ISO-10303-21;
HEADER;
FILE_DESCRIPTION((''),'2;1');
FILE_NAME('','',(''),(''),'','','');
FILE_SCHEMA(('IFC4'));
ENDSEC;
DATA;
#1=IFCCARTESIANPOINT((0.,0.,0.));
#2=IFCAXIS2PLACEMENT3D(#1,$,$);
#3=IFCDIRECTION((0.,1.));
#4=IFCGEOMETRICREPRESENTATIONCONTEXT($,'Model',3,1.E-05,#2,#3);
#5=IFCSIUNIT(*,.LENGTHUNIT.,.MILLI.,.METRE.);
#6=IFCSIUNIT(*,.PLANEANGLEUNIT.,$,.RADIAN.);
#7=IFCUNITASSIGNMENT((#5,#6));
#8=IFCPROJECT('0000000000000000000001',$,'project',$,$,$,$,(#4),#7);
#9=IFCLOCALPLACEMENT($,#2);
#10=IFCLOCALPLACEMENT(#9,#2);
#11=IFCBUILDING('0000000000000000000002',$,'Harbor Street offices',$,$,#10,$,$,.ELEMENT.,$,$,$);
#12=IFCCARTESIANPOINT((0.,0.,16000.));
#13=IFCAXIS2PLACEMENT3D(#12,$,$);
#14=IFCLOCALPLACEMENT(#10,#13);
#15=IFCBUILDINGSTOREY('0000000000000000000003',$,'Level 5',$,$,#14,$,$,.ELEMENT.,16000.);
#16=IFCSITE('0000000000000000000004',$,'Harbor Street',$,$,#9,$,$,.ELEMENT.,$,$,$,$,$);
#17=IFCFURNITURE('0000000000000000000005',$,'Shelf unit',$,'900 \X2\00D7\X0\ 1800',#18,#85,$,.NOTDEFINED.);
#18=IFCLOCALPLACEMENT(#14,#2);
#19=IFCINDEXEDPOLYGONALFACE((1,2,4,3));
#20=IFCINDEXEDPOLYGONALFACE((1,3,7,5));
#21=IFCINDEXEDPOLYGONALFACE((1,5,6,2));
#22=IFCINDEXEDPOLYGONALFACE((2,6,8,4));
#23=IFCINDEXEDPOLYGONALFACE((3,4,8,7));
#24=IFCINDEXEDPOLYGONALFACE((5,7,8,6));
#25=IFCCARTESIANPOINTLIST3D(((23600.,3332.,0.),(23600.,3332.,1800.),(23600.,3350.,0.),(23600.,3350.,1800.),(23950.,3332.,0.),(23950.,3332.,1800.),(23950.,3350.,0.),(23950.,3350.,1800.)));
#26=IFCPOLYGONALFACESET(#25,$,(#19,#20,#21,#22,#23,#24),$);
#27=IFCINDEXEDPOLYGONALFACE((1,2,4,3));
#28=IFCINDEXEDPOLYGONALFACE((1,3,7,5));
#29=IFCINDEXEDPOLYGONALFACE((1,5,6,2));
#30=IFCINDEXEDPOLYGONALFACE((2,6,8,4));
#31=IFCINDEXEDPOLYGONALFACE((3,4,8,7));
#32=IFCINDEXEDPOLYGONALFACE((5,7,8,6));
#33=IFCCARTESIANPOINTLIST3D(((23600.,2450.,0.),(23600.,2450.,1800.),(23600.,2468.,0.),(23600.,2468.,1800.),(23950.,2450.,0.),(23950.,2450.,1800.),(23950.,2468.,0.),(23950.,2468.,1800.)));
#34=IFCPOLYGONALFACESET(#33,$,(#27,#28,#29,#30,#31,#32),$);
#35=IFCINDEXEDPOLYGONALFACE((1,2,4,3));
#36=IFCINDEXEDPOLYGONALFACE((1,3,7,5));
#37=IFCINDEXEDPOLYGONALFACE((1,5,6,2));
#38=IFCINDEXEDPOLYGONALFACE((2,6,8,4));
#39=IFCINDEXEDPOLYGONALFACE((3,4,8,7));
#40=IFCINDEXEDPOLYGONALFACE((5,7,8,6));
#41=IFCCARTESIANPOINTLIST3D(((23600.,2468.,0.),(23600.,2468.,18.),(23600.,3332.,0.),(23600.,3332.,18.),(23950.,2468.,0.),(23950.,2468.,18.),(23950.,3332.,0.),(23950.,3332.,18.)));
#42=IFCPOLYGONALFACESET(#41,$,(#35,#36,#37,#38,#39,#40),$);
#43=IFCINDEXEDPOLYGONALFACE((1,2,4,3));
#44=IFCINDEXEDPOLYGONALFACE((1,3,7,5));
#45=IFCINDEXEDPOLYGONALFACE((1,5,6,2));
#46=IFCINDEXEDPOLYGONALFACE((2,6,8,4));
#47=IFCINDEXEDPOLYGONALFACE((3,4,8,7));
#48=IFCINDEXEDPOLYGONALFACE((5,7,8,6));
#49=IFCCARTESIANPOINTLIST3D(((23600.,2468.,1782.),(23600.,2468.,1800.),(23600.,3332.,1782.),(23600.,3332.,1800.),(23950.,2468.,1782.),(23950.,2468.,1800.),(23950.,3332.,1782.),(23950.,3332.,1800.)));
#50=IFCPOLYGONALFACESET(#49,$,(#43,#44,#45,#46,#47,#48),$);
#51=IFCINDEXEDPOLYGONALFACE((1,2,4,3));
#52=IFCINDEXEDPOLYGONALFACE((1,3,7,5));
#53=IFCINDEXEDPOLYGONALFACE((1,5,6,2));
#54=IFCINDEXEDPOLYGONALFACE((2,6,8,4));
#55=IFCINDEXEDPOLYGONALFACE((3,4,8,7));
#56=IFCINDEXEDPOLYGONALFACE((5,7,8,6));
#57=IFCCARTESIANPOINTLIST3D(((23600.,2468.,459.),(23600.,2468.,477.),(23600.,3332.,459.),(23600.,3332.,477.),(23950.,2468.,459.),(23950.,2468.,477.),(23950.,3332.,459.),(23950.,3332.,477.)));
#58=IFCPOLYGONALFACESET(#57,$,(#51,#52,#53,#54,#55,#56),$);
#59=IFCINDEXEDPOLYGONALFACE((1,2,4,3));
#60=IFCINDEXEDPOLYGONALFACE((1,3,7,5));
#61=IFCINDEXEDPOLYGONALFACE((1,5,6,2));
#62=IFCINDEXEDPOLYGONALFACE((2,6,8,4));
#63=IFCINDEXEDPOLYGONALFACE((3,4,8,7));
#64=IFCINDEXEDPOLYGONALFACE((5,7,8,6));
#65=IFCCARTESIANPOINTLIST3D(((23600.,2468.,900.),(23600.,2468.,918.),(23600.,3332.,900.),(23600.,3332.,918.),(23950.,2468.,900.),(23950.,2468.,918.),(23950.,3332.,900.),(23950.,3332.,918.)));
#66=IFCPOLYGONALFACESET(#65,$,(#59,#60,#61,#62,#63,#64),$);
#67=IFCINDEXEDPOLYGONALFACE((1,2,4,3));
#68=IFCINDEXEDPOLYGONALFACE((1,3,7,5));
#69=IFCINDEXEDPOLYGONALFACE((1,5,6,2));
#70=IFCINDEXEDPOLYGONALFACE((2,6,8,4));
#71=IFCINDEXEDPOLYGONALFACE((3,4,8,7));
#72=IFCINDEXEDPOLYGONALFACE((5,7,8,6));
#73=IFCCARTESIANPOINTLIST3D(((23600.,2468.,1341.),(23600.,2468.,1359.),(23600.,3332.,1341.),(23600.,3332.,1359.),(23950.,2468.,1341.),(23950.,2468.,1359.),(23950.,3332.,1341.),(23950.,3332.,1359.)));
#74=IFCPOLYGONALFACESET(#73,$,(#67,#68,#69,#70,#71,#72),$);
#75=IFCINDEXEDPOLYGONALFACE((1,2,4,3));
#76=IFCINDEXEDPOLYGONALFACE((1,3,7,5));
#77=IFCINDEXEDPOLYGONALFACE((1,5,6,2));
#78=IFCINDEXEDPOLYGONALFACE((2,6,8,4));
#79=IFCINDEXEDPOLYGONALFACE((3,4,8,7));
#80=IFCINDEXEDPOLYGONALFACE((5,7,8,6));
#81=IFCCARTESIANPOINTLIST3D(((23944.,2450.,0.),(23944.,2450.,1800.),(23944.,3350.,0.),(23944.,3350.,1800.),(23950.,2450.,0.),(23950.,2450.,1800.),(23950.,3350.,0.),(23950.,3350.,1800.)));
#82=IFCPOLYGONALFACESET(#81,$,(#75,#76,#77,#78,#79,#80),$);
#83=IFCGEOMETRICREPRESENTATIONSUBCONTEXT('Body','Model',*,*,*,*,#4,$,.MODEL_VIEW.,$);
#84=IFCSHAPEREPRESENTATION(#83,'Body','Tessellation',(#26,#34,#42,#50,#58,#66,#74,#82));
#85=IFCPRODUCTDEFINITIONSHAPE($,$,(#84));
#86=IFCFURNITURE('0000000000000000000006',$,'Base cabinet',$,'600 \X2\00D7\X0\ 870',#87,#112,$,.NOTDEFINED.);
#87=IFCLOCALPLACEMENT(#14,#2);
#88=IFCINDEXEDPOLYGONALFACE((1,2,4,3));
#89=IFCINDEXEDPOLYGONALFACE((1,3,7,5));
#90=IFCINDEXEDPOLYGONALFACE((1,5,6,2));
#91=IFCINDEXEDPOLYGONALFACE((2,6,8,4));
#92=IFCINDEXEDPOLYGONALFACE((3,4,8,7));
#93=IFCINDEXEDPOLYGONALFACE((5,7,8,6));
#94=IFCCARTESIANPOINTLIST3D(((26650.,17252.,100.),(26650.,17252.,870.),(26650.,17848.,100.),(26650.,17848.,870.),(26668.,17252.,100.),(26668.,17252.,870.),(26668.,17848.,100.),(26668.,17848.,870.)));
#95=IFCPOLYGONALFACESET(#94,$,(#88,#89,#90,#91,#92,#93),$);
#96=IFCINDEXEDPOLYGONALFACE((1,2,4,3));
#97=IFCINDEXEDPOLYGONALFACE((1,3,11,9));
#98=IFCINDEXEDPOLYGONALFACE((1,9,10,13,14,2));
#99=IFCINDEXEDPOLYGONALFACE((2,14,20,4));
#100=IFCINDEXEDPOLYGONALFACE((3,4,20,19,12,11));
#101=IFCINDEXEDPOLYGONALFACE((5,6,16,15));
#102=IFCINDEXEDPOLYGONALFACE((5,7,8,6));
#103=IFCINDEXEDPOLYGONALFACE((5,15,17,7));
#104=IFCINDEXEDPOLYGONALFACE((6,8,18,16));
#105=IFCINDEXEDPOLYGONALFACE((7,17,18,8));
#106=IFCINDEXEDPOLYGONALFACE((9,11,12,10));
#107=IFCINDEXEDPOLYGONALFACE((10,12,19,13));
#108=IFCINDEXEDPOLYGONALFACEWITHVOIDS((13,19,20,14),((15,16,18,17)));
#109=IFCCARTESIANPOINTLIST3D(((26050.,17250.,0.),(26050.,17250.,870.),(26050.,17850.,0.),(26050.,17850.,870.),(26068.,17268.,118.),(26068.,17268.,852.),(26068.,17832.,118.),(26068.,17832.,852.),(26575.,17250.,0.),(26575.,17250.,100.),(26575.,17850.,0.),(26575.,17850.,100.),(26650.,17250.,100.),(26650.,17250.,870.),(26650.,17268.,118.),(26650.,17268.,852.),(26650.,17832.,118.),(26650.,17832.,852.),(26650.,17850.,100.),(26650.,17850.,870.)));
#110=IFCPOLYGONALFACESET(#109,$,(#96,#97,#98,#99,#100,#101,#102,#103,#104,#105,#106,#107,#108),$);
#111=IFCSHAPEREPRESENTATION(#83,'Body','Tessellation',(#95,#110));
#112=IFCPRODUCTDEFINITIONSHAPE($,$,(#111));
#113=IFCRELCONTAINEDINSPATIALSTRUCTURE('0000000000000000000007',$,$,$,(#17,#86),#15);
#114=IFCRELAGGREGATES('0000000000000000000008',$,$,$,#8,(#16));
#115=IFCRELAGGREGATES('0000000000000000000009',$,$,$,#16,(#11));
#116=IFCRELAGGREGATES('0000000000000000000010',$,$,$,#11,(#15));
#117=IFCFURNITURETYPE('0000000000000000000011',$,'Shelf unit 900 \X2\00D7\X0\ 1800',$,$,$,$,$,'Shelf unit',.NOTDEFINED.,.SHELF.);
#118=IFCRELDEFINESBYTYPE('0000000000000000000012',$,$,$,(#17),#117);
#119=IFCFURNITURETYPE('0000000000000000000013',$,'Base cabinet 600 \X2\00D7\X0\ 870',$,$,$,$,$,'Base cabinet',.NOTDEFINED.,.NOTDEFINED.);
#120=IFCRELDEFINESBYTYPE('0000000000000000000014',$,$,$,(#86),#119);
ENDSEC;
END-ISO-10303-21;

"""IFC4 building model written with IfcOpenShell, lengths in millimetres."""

from ifc_helpers import new_model, entity, si_unit, direction, frame, origin, place, context, subcontext, project, spatial, polyline, outline, extrude, source, transform, mapped, type_object, type_shapes, element, save


model = new_model("IFC4")

# Units and contexts
model_context = context("Model", 3, precision=1e-05, world=origin(), true_north=direction((0.0, 1.0)))
body_context = subcontext(model_context, "Body", "Model", "MODEL_VIEW")
ifc_project = project(units=[si_unit("LENGTHUNIT", "METRE", prefix="MILLI"), si_unit("PLANEANGLEUNIT", "RADIAN")], contexts=[model_context])

# Site, building, storey
site_placement = place(None, origin())
site = spatial("IfcSite", under=ifc_project, at=site_placement, Name="Harbor Street", CompositionType="ELEMENT")
building_placement = place(site_placement, origin())
building = spatial("IfcBuilding", under=site, at=building_placement, Name="Harbor Street offices", CompositionType="ELEMENT")
storey_placement = place(building_placement, frame((0.0, 0.0, 16000.0)))
storey = spatial("IfcBuildingStorey", under=building, at=storey_placement, Name="Level 5", CompositionType="ELEMENT", Elevation=16000.0)

# Furniture
furniture_type_1 = type_object("IfcFurnitureType", Name="Shelf unit 900 × 1800", ElementType="Shelf unit", AssemblyPlace="NOTDEFINED", PredefinedType="SHELF")
shared_shape_1 = source(origin(), body_context, "Body", "SweptSolid", [
    extrude(outline(polyline([(-450.0, 0.0), (-432.0, 0.0), (-432.0, 350.0), (-450.0, 350.0), (-450.0, 0.0)])), origin(), (0.0, 0.0, 1.0), 1800.0),
    extrude(outline(polyline([(432.0, 0.0), (450.0, 0.0), (450.0, 350.0), (432.0, 350.0), (432.0, 0.0)])), origin(), (0.0, 0.0, 1.0), 1800.0),
    extrude(outline(polyline([(-432.0, 0.0), (432.0, 0.0), (432.0, 350.0), (-432.0, 350.0), (-432.0, 0.0)])), origin(), (0.0, 0.0, 1.0), 18.0),
    extrude(outline(polyline([(-432.0, 0.0), (432.0, 0.0), (432.0, 350.0), (-432.0, 350.0), (-432.0, 0.0)])), frame((0.0, 0.0, 1782.0)), (0.0, 0.0, 1.0), 18.0),
    extrude(outline(polyline([(-432.0, 0.0), (432.0, 0.0), (432.0, 350.0), (-432.0, 350.0), (-432.0, 0.0)])), frame((0.0, 0.0, 459.0)), (0.0, 0.0, 1.0), 18.0),
    extrude(outline(polyline([(-432.0, 0.0), (432.0, 0.0), (432.0, 350.0), (-432.0, 350.0), (-432.0, 0.0)])), frame((0.0, 0.0, 900.0)), (0.0, 0.0, 1.0), 18.0),
    extrude(outline(polyline([(-432.0, 0.0), (432.0, 0.0), (432.0, 350.0), (-432.0, 350.0), (-432.0, 0.0)])), frame((0.0, 0.0, 1341.0)), (0.0, 0.0, 1.0), 18.0),
    extrude(outline(polyline([(-450.0, 344.0), (450.0, 344.0), (450.0, 350.0), (-450.0, 350.0), (-450.0, 344.0)])), origin(), (0.0, 0.0, 1.0), 1800.0),
])
type_shapes(furniture_type_1, [shared_shape_1])
for number, where, z_axis, x_axis, name in (
    (1, (23600.0, 2900.0, 0.0), (0.0, 0.0, 1.0), (0.0, -1.0, 0.0), "Shelf unit"),
):
    element("IfcFurniture", number, at=place(storey_placement, frame(where, z_axis=z_axis, x_axis=x_axis)), inside=storey, type_object=furniture_type_1, Name=name, ObjectType="900 × 1800", PredefinedType="NOTDEFINED", context=body_context, shape_type="MappedRepresentation", body=[
        mapped(shared_shape_1, transform((0.0, 0.0, 0.0))),
    ])
furniture_type_2 = type_object("IfcFurnitureType", Name="Base cabinet 600 × 870", ElementType="Base cabinet", AssemblyPlace="NOTDEFINED", PredefinedType="NOTDEFINED")
cartesian_point_1 = entity("IfcCartesianPoint", [-300.0, 0.0])
cartesian_point_2 = entity("IfcCartesianPoint", [-282.0, -1.0])
cartesian_point_3 = entity("IfcCartesianPoint", [-301.0, -1.0])
shared_shape_2 = source(origin(), body_context, "Body", "SolidModel", [
    extrude(outline(polyline([(-298.0, -18.0), (298.0, -18.0), (298.0, 0.0), (-298.0, 0.0), (-298.0, -18.0)])), frame((0.0, 0.0, 100.0)), (0.0, 0.0, 1.0), 770.0),
    entity("IfcCsgSolid", entity("IfcBooleanResult", "DIFFERENCE", entity("IfcBooleanResult", "DIFFERENCE", entity("IfcExtrudedAreaSolid", entity("IfcArbitraryClosedProfileDef", "AREA", None, entity("IfcPolyline", [cartesian_point_1, entity("IfcCartesianPoint", [300.0, 0.0]), entity("IfcCartesianPoint", [300.0, 600.0]), entity("IfcCartesianPoint", [-300.0, 600.0]), cartesian_point_1])), entity("IfcAxis2Placement3D", entity("IfcCartesianPoint", [0.0, 0.0, 0.0])), entity("IfcDirection", [0.0, 0.0, 1.0]), 870.0), entity("IfcExtrudedAreaSolid", entity("IfcArbitraryClosedProfileDef", "AREA", None, entity("IfcPolyline", [cartesian_point_2, entity("IfcCartesianPoint", [282.0, -1.0]), entity("IfcCartesianPoint", [282.0, 582.0]), entity("IfcCartesianPoint", [-282.0, 582.0]), cartesian_point_2])), entity("IfcAxis2Placement3D", entity("IfcCartesianPoint", [0.0, 0.0, 118.0])), entity("IfcDirection", [0.0, 0.0, 1.0]), 734.0)), entity("IfcExtrudedAreaSolid", entity("IfcArbitraryClosedProfileDef", "AREA", None, entity("IfcPolyline", [cartesian_point_3, entity("IfcCartesianPoint", [301.0, -1.0]), entity("IfcCartesianPoint", [301.0, 75.0]), entity("IfcCartesianPoint", [-301.0, 75.0]), cartesian_point_3])), entity("IfcAxis2Placement3D", entity("IfcCartesianPoint", [0.0, 0.0, -1.0])), entity("IfcDirection", [0.0, 0.0, 1.0]), 101.0))),
])
type_shapes(furniture_type_2, [shared_shape_2])
furniture_placement = place(storey_placement, frame((26650.0, 17550.0, 0.0), z_axis=(0.0, 0.0, 1.0), x_axis=(0.0, 1.0, 0.0)))
element("IfcFurniture", 2, at=furniture_placement, inside=storey, type_object=furniture_type_2, Name="Base cabinet", ObjectType="600 × 870", PredefinedType="NOTDEFINED", context=body_context, shape_type="MappedRepresentation", body=[
    mapped(shared_shape_2, transform((0.0, 0.0, 0.0))),
])

save(model, "model.ifc")
